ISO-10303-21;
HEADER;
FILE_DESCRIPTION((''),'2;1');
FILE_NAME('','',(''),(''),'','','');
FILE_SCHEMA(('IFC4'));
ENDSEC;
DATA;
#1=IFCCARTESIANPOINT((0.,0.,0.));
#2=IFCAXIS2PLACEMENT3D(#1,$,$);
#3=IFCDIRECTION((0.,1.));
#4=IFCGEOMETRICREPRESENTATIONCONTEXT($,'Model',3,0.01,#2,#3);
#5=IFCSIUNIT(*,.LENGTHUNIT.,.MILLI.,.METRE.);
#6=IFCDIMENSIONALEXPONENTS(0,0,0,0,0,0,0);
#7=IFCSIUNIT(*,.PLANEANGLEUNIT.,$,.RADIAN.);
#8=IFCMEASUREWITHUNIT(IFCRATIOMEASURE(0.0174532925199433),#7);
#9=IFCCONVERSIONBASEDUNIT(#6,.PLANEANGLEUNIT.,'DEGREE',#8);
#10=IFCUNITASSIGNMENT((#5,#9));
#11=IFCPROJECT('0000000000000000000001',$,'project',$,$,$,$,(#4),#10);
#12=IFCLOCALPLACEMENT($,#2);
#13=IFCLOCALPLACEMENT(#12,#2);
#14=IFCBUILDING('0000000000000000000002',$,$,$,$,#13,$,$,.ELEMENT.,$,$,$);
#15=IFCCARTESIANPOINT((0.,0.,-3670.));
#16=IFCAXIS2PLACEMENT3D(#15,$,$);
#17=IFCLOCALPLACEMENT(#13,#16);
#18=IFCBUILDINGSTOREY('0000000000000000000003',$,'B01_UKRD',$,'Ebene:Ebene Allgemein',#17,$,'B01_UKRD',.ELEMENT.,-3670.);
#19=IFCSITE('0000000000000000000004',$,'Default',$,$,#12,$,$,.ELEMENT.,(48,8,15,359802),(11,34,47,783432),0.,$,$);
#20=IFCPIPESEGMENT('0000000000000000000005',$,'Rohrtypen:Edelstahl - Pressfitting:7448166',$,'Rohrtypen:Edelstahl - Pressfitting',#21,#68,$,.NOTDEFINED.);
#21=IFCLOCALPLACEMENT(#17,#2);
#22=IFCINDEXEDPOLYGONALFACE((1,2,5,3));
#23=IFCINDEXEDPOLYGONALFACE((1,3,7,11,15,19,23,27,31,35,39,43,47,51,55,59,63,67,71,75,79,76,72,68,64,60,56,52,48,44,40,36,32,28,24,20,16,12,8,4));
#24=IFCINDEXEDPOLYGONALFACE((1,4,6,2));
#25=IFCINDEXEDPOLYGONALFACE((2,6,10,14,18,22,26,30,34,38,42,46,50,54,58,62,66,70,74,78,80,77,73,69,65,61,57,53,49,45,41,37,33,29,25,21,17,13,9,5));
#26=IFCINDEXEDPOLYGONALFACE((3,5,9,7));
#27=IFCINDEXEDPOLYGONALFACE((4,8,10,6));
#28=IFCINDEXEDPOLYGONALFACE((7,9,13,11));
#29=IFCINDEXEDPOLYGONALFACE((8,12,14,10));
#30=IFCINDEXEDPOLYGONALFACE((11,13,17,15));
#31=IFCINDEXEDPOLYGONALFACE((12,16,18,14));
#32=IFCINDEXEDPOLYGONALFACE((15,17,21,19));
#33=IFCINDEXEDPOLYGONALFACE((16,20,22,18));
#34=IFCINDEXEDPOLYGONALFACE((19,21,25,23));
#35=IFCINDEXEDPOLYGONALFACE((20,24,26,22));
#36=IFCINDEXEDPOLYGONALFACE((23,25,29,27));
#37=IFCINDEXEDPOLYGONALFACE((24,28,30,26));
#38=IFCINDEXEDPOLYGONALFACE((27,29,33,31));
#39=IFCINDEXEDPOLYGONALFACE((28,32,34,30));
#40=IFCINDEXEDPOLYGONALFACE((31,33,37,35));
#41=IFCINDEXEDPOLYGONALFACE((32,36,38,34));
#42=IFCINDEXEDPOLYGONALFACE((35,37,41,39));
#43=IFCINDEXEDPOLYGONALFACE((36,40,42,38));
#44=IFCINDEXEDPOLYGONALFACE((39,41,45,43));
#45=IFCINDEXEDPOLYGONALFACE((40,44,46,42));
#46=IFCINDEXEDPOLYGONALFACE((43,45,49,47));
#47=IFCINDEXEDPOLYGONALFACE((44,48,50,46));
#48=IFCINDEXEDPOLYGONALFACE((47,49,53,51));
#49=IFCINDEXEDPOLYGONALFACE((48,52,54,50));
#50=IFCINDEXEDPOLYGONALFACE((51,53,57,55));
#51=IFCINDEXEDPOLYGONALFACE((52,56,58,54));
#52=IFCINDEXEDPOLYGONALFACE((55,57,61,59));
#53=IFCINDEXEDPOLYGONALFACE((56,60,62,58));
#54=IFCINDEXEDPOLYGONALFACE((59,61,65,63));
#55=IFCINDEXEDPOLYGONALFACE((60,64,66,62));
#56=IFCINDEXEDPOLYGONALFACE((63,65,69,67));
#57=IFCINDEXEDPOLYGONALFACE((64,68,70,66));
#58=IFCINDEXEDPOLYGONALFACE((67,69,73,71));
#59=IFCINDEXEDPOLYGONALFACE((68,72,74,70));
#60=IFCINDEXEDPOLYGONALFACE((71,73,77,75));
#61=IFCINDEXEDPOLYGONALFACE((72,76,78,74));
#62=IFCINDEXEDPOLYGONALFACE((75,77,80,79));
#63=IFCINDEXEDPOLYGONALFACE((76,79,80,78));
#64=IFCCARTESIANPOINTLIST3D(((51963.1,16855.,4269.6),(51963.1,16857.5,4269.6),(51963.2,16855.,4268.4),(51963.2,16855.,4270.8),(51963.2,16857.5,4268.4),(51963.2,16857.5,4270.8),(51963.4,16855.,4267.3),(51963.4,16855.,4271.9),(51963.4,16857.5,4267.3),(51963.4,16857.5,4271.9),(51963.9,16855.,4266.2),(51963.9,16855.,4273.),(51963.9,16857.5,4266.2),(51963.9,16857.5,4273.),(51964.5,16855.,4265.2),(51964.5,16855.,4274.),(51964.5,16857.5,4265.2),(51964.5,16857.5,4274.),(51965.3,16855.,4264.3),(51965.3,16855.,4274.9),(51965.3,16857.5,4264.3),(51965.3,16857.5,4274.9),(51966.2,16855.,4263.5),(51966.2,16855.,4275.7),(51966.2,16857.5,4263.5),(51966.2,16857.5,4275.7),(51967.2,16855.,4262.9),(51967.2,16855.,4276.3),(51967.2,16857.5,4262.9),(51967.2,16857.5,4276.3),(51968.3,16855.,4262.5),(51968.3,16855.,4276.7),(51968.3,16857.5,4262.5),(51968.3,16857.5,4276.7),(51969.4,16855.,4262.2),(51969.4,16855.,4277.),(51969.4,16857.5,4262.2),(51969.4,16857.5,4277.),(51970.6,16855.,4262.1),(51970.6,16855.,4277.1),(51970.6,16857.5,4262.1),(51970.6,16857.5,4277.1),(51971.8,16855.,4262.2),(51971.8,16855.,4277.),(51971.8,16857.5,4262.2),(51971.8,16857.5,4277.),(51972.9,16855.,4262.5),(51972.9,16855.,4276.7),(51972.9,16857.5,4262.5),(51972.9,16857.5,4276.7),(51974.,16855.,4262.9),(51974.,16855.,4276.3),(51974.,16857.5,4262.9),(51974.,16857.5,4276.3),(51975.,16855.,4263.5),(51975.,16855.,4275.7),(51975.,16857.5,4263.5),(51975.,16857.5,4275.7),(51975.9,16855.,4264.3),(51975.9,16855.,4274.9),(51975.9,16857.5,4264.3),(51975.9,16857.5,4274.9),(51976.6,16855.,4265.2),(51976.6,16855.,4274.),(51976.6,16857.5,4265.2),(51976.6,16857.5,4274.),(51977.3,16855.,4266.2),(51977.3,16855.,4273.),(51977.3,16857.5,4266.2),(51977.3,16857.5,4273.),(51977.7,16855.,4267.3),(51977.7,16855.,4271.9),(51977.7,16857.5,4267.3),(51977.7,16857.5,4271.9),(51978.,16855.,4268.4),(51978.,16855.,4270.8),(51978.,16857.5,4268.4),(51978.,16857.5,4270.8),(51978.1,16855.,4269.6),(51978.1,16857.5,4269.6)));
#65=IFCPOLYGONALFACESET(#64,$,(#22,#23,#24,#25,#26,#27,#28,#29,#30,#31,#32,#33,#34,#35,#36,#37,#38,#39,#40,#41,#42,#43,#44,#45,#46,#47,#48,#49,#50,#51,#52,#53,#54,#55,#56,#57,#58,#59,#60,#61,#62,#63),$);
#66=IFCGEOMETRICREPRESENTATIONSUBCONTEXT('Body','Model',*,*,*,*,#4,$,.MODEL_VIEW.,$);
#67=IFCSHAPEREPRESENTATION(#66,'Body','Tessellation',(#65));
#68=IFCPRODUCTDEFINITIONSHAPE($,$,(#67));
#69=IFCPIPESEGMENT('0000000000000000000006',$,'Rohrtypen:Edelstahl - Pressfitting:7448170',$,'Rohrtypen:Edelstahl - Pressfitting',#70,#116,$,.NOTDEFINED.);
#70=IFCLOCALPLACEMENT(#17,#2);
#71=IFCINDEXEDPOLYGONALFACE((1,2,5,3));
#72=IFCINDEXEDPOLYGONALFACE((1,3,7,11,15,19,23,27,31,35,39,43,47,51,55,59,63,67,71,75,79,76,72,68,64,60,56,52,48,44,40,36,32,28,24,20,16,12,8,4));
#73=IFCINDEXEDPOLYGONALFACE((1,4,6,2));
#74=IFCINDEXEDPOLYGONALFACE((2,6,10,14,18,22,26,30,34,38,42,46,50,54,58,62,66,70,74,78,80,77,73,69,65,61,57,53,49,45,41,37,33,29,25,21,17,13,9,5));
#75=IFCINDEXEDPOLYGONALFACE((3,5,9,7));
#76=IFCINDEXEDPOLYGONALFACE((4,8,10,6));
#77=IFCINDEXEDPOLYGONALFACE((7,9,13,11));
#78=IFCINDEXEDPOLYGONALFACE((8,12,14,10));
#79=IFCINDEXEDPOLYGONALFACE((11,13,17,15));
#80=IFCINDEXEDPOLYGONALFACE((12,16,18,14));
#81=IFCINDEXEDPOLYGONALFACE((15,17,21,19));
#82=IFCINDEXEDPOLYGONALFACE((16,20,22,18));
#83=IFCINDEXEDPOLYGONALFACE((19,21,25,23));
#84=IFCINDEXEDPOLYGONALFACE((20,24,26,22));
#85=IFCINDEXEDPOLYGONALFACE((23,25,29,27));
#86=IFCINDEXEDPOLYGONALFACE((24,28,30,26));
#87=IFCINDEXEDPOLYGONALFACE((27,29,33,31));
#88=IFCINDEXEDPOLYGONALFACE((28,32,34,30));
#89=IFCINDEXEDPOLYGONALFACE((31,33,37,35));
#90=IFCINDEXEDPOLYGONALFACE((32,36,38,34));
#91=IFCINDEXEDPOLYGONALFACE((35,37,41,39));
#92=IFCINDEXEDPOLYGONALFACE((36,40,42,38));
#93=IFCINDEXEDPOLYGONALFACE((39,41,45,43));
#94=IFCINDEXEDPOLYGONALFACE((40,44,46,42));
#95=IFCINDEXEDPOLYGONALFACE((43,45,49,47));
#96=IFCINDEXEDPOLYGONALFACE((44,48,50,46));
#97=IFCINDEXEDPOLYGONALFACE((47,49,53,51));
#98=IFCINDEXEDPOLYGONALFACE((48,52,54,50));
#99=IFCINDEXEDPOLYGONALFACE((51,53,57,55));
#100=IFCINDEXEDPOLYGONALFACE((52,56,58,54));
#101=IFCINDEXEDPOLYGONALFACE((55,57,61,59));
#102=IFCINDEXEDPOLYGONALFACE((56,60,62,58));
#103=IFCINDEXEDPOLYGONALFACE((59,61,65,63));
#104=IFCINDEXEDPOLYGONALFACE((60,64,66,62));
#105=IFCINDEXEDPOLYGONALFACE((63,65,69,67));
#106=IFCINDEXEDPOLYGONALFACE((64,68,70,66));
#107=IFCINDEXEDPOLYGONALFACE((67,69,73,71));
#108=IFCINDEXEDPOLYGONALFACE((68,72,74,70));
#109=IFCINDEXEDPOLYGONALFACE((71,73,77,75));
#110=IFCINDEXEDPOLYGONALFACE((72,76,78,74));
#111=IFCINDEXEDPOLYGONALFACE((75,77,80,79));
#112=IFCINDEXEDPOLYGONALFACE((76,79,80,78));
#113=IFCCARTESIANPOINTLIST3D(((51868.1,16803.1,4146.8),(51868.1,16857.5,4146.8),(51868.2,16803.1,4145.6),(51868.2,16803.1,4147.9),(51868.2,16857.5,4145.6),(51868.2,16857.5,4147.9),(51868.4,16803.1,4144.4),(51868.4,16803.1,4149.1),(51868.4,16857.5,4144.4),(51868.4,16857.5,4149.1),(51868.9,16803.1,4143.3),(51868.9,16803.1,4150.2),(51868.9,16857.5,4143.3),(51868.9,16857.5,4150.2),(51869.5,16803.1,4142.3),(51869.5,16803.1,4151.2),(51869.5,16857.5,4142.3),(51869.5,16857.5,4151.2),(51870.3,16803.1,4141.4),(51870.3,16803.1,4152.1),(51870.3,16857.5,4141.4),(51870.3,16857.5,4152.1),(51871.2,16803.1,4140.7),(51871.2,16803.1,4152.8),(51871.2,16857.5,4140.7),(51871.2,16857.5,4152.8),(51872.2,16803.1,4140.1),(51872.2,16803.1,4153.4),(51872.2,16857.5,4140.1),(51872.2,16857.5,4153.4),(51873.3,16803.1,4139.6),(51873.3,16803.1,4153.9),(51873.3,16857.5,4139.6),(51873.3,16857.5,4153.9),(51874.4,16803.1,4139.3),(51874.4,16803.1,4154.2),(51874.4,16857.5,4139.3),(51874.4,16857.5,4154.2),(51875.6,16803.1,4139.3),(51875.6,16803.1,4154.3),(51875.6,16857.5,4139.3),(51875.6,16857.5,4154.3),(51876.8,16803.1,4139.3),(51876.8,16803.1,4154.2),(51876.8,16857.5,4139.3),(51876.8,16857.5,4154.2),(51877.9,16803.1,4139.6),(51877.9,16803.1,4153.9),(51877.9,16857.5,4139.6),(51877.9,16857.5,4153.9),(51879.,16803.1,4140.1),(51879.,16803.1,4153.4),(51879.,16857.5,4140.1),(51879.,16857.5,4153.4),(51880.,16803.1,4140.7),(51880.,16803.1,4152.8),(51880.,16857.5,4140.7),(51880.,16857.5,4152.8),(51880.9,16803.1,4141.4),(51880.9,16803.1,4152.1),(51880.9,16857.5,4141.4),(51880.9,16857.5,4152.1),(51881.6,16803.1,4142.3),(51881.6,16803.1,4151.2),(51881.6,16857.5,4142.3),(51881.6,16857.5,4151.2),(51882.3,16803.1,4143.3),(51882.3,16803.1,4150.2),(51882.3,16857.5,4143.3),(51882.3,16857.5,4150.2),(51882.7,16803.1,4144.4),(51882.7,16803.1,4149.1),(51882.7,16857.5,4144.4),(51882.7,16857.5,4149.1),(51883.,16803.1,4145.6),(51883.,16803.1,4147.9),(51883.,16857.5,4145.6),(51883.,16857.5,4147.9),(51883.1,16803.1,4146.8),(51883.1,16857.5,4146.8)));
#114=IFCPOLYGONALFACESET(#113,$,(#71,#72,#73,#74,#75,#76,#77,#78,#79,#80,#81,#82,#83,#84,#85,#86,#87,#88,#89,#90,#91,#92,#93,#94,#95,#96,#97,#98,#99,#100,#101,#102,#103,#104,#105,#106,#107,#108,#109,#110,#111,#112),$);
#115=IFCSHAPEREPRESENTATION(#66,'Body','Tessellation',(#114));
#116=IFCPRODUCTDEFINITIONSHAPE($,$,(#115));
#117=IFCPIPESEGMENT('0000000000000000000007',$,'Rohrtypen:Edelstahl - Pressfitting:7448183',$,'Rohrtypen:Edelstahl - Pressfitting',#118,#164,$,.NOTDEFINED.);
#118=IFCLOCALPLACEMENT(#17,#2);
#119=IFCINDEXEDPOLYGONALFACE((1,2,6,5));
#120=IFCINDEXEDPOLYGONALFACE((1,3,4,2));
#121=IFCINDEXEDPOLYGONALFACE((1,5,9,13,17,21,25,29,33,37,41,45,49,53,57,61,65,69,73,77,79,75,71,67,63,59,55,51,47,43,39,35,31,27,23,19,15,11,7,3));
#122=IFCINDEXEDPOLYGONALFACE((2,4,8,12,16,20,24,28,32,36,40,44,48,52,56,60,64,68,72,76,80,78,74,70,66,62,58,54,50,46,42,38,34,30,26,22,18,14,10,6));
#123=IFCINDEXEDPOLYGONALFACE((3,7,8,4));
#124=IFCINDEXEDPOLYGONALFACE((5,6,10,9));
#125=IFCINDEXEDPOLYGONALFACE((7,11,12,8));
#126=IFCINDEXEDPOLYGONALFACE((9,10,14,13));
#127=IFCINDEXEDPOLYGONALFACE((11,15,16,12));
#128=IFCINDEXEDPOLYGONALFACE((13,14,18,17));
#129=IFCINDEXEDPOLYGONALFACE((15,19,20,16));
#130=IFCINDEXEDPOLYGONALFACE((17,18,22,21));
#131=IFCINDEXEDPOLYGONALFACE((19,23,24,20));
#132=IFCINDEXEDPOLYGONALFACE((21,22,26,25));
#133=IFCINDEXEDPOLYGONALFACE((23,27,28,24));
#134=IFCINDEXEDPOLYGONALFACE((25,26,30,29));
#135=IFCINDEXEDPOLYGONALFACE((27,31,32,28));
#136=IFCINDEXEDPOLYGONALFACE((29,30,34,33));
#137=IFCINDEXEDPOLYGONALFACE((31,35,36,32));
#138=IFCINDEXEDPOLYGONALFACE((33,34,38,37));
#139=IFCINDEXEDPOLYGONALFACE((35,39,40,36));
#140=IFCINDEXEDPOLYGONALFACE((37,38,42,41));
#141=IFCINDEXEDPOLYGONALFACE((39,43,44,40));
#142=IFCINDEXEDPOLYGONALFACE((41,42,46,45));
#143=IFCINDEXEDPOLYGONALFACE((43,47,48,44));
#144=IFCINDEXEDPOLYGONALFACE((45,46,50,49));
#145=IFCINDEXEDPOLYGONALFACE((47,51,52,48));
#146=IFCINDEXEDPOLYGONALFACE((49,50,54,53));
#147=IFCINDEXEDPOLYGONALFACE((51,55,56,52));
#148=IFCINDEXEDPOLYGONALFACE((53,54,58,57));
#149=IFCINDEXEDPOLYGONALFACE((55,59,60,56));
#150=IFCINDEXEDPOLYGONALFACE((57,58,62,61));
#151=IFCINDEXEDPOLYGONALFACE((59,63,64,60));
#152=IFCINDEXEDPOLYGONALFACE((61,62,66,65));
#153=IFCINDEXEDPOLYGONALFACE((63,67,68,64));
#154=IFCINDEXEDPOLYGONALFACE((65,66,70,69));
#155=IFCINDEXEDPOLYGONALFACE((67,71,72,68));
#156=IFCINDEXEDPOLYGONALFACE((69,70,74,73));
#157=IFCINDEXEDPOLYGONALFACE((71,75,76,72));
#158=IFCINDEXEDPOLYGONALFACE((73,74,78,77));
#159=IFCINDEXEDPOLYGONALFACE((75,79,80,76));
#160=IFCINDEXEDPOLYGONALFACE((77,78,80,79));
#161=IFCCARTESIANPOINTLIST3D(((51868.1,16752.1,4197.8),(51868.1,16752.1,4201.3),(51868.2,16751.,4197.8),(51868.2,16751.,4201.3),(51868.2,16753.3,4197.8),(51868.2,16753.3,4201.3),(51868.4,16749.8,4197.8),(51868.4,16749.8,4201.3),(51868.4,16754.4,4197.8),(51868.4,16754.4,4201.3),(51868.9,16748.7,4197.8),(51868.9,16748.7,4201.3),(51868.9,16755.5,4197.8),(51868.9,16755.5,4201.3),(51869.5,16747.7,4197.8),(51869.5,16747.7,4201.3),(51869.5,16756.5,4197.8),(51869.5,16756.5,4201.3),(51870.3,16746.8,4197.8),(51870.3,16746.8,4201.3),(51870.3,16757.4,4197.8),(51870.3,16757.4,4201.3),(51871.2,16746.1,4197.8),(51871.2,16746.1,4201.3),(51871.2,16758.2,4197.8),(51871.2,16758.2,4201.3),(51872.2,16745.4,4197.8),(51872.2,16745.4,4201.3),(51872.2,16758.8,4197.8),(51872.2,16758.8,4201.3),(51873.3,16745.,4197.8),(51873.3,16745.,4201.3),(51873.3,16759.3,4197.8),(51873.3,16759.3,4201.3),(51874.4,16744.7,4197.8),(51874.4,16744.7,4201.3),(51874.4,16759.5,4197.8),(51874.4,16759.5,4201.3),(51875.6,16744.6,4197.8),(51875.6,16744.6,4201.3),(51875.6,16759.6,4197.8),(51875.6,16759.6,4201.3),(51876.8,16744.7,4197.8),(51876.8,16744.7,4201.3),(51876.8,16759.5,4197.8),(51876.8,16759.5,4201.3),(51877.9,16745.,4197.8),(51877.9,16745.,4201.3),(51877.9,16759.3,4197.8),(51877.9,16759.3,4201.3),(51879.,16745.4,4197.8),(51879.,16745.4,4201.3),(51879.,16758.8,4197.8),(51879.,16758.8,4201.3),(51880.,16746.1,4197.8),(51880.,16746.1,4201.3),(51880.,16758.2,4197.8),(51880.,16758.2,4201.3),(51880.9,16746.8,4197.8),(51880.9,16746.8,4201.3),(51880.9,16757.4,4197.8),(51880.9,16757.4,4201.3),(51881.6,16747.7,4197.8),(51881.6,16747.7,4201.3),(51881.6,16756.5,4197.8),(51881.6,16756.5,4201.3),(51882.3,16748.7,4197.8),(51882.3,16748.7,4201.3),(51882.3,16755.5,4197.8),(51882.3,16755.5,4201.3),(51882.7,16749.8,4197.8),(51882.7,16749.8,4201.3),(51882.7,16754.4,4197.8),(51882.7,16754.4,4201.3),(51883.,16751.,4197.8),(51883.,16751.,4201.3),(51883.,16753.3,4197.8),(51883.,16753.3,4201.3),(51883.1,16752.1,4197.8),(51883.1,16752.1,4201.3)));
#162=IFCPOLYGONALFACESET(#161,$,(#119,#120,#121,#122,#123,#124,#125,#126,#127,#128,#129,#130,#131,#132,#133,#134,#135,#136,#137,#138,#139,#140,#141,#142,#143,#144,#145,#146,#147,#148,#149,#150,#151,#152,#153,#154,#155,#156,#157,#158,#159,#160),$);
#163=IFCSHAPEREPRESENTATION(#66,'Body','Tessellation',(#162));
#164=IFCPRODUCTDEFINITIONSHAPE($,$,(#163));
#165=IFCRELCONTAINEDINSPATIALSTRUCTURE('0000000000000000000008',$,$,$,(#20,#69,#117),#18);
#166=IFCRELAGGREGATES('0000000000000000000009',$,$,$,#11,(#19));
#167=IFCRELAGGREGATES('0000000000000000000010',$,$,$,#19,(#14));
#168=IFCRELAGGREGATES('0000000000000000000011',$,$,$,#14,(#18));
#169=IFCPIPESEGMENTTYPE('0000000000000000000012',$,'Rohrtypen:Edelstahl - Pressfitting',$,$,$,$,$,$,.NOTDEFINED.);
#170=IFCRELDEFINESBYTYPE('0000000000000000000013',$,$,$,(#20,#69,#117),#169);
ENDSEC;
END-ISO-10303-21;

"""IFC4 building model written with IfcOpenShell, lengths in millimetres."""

from ifc_helpers import new_model, entity, si_unit, converted_unit, direction, frame, origin, place, context, subcontext, project, spatial, indexed_curve, outline, extrude, type_object, element, save


model = new_model("IFC4")

# Units and contexts
model_context = context("Model", 3, precision=0.01, world=origin(), true_north=direction((0.0, 1.0)))
body_context = subcontext(model_context, "Body", "Model", "MODEL_VIEW")
ifc_project = project(units=[si_unit("LENGTHUNIT", "METRE", prefix="MILLI"), converted_unit("PLANEANGLEUNIT", "DEGREE", entity("IfcRatioMeasure", 0.0174532925199433), si_unit("PLANEANGLEUNIT", "RADIAN"), dimensions=[0, 0, 0, 0, 0, 0, 0])], contexts=[model_context])

# Site, building, storey
site_placement = place(None, origin())
site = spatial("IfcSite", under=ifc_project, at=site_placement, Name="Default", CompositionType="ELEMENT", RefLatitude=(48, 8, 15, 359802), RefLongitude=(11, 34, 47, 783432), RefElevation=0.0)
building_placement = place(site_placement, origin())
building = spatial("IfcBuilding", under=site, at=building_placement, CompositionType="ELEMENT")
storey_placement = place(building_placement, frame((0.0, 0.0, -3670.0)))
storey = spatial("IfcBuildingStorey", under=building, at=storey_placement, Name="B01_UKRD", ObjectType="Ebene:Ebene Allgemein", LongName="B01_UKRD", CompositionType="ELEMENT", Elevation=-3670.0)

# Pipe segments
pipe_segment_type = type_object("IfcPipeSegmentType", Name="Rohrtypen:Edelstahl - Pressfitting", PredefinedType="NOTDEFINED")
pipe_segment_1_placement = place(storey_placement, origin())
element("IfcPipeSegment", 1, at=pipe_segment_1_placement, inside=storey, type_object=pipe_segment_type, Name="Rohrtypen:Edelstahl - Pressfitting:7448166", ObjectType="Rohrtypen:Edelstahl - Pressfitting", PredefinedType="NOTDEFINED", context=body_context, shape_type="SweptSolid", body=[
    extrude(outline(indexed_curve([(7.5, 0.0), (7.4, 1.2), (7.1, 2.3), (6.7, 3.4), (6.1, 4.4), (5.3, 5.3), (4.4, 6.1), (3.4, 6.7), (2.3, 7.1), (1.2, 7.4), (0.0, 7.5), (-1.2, 7.4), (-2.3, 7.1), (-3.4, 6.7), (-4.4, 6.1), (-5.3, 5.3), (-6.1, 4.4), (-6.7, 3.4), (-7.1, 2.3), (-7.4, 1.2), (-7.5, 0.0), (-7.4, -1.2), (-7.1, -2.3), (-6.7, -3.4), (-6.1, -4.4), (-5.3, -5.3), (-4.4, -6.1), (-3.4, -6.7), (-2.3, -7.1), (-1.2, -7.4), (0.0, -7.5), (1.2, -7.4), (2.3, -7.1), (3.4, -6.7), (4.4, -6.1), (5.3, -5.3), (6.1, -4.4), (6.7, -3.4), (7.1, -2.3), (7.4, -1.2), (7.5, 0.0)], self_intersect=False)), frame((51970.6, 16855.0, 4269.6), z_axis=(0.0, 1.0, 0.0), x_axis=(-1.0, 0.0, 0.0)), (0.0, 0.0, 1.0), 2.6),
])
pipe_segment_2_placement = place(storey_placement, origin())
element("IfcPipeSegment", 2, at=pipe_segment_2_placement, inside=storey, type_object=pipe_segment_type, Name="Rohrtypen:Edelstahl - Pressfitting:7448170", ObjectType="Rohrtypen:Edelstahl - Pressfitting", PredefinedType="NOTDEFINED", context=body_context, shape_type="SweptSolid", body=[
    extrude(outline(indexed_curve([(7.5, 0.0), (7.4, 1.2), (7.1, 2.3), (6.7, 3.4), (6.1, 4.4), (5.3, 5.3), (4.4, 6.1), (3.4, 6.7), (2.3, 7.1), (1.2, 7.4), (0.0, 7.5), (-1.2, 7.4), (-2.3, 7.1), (-3.4, 6.7), (-4.4, 6.1), (-5.3, 5.3), (-6.1, 4.4), (-6.7, 3.4), (-7.1, 2.3), (-7.4, 1.2), (-7.5, 0.0), (-7.4, -1.2), (-7.1, -2.3), (-6.7, -3.4), (-6.1, -4.4), (-5.3, -5.3), (-4.4, -6.1), (-3.4, -6.7), (-2.3, -7.1), (-1.2, -7.4), (0.0, -7.5), (1.2, -7.4), (2.3, -7.1), (3.4, -6.7), (4.4, -6.1), (5.3, -5.3), (6.1, -4.4), (6.7, -3.4), (7.1, -2.3), (7.4, -1.2), (7.5, 0.0)], self_intersect=False)), frame((51875.6, 16803.1, 4146.8), z_axis=(0.0, 1.0, 0.0), x_axis=(-1.0, 0.0, 0.0)), (0.0, 0.0, 1.0), 54.4),
])
pipe_segment_3_placement = place(storey_placement, origin())
element("IfcPipeSegment", 3, at=pipe_segment_3_placement, inside=storey, type_object=pipe_segment_type, Name="Rohrtypen:Edelstahl - Pressfitting:7448183", ObjectType="Rohrtypen:Edelstahl - Pressfitting", PredefinedType="NOTDEFINED", context=body_context, shape_type="SweptSolid", body=[
    extrude(outline(indexed_curve([(7.5, 0.0), (7.4, 1.2), (7.1, 2.3), (6.7, 3.4), (6.1, 4.4), (5.3, 5.3), (4.4, 6.1), (3.4, 6.7), (2.3, 7.1), (1.2, 7.4), (0.0, 7.5), (-1.2, 7.4), (-2.3, 7.1), (-3.4, 6.7), (-4.4, 6.1), (-5.3, 5.3), (-6.1, 4.4), (-6.7, 3.4), (-7.1, 2.3), (-7.4, 1.2), (-7.5, 0.0), (-7.4, -1.2), (-7.1, -2.3), (-6.7, -3.4), (-6.1, -4.4), (-5.3, -5.3), (-4.4, -6.1), (-3.4, -6.7), (-2.3, -7.1), (-1.2, -7.4), (0.0, -7.5), (1.2, -7.4), (2.3, -7.1), (3.4, -6.7), (4.4, -6.1), (5.3, -5.3), (6.1, -4.4), (6.7, -3.4), (7.1, -2.3), (7.4, -1.2), (7.5, 0.0)], self_intersect=False)), frame((51875.6, 16752.1, 4197.8), z_axis=(0.0, 0.0, 1.0), x_axis=(-1.0, 0.0, 0.0)), (0.0, 0.0, 1.0), 3.5),
])

save(model, "model.ifc")
